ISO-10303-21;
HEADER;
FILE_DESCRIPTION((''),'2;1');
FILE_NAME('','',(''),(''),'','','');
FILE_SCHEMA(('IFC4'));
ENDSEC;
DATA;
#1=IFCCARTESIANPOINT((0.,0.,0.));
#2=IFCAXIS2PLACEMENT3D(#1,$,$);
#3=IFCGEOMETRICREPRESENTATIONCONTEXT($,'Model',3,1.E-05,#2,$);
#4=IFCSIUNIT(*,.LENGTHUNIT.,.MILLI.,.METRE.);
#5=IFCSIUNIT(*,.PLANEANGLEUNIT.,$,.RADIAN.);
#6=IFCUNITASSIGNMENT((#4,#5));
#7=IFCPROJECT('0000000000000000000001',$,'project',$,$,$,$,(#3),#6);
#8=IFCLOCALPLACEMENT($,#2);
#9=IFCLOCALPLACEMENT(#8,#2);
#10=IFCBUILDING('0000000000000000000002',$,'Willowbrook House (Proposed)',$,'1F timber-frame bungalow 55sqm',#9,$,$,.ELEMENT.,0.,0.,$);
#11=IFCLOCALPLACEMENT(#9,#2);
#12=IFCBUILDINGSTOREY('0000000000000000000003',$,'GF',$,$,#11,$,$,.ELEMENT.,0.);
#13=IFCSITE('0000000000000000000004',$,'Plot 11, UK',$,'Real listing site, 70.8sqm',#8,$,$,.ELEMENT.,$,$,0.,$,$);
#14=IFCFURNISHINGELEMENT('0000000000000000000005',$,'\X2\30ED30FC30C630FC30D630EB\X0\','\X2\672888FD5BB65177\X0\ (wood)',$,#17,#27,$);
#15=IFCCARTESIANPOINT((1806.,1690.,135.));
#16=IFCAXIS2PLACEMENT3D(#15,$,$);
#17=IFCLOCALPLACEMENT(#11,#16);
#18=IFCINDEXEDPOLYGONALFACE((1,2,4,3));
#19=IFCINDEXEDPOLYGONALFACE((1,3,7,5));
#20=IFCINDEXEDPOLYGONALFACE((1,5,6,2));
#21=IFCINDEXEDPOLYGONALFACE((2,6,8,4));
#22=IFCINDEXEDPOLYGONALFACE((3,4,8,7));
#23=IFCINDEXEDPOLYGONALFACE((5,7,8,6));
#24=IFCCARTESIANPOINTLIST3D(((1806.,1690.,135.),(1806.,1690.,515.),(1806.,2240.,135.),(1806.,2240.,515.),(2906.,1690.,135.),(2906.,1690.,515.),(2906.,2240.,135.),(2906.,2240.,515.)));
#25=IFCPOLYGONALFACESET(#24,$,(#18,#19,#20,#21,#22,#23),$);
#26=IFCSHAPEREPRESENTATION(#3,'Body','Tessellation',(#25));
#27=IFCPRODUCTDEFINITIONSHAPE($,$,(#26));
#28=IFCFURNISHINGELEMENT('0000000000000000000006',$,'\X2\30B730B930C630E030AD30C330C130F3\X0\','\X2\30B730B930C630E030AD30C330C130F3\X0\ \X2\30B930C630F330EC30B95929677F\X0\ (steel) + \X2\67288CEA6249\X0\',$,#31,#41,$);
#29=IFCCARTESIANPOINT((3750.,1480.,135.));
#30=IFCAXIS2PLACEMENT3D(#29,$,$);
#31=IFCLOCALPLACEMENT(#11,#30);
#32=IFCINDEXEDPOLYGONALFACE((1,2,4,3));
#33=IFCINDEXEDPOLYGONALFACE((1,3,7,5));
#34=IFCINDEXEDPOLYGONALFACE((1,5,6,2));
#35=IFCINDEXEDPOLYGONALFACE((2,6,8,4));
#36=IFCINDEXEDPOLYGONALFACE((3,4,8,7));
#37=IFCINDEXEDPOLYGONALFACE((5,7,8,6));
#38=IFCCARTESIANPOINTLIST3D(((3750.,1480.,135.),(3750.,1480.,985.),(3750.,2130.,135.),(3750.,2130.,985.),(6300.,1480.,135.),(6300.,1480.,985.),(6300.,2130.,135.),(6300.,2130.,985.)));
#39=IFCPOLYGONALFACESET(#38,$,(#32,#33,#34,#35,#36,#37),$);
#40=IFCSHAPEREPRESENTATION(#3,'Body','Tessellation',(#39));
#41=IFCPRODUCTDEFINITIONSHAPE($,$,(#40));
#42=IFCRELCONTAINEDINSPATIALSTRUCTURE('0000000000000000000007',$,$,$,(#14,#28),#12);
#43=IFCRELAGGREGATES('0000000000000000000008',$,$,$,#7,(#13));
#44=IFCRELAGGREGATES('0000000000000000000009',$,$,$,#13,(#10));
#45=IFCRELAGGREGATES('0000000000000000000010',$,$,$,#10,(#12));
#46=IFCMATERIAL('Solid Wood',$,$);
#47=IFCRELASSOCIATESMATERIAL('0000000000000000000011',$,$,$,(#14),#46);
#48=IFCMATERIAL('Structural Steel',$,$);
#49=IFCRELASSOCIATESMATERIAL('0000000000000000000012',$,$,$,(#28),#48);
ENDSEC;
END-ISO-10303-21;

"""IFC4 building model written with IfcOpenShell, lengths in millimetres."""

from ifc_helpers import new_model, si_unit, frame, frame_2d, origin, place, context, project, spatial, rectangle, extrude, material, element, save


model = new_model("IFC4")

# Units and contexts
model_context = context("Model", 3, precision=1e-05, world=origin())
ifc_project = project(units=[si_unit("LENGTHUNIT", "METRE", prefix="MILLI"), si_unit("PLANEANGLEUNIT", "RADIAN")], contexts=[model_context])

# Site, building, storey
site_placement = place(None, origin())
site = spatial("IfcSite", under=ifc_project, at=site_placement, Name="Plot 11, UK", ObjectType="Real listing site, 70.8sqm", CompositionType="ELEMENT", RefElevation=0.0)
building_placement = place(site_placement, origin())
building = spatial("IfcBuilding", under=site, at=building_placement, Name="Willowbrook House (Proposed)", ObjectType="1F timber-frame bungalow 55sqm", CompositionType="ELEMENT", ElevationOfRefHeight=0.0, ElevationOfTerrain=0.0)
storey_placement = place(building_placement, origin())
storey = spatial("IfcBuildingStorey", under=building, at=storey_placement, Name="GF", CompositionType="ELEMENT", Elevation=0.0)

# Shared definitions
ifc_material_1 = material(Name="Solid Wood")

# Furnishing elements
furnishing_1_placement = place(storey_placement, frame((1806.0, 1690.0, 135.0)))
element("IfcFurnishingElement", 1, at=furnishing_1_placement, inside=storey, material=ifc_material_1, Name="ローテーブル", Description="木製家具 (wood)", context=model_context, shape_type="SweptSolid", body=[
    extrude(rectangle(XDim=1100.0, YDim=550.0, at=frame_2d((550.0, 275.0))), frame((1806.0, 1690.0, 135.0)), (0.0, 0.0, 1.0), 380.0),
])
ifc_material_2 = material(Name="Structural Steel")
furnishing_2_placement = place(storey_placement, frame((3750.0, 1480.0, 135.0)))
element("IfcFurnishingElement", 2, at=furnishing_2_placement, inside=storey, material=ifc_material_2, Name="システムキッチン", Description="システムキッチン ステンレス天板 (steel) + 木質扉", context=model_context, shape_type="SweptSolid", body=[
    extrude(rectangle(XDim=2550.0, YDim=650.0, at=frame_2d((1275.0, 325.0))), frame((3750.0, 1480.0, 135.0)), (0.0, 0.0, 1.0), 850.0),
])

save(model, "model.ifc")
